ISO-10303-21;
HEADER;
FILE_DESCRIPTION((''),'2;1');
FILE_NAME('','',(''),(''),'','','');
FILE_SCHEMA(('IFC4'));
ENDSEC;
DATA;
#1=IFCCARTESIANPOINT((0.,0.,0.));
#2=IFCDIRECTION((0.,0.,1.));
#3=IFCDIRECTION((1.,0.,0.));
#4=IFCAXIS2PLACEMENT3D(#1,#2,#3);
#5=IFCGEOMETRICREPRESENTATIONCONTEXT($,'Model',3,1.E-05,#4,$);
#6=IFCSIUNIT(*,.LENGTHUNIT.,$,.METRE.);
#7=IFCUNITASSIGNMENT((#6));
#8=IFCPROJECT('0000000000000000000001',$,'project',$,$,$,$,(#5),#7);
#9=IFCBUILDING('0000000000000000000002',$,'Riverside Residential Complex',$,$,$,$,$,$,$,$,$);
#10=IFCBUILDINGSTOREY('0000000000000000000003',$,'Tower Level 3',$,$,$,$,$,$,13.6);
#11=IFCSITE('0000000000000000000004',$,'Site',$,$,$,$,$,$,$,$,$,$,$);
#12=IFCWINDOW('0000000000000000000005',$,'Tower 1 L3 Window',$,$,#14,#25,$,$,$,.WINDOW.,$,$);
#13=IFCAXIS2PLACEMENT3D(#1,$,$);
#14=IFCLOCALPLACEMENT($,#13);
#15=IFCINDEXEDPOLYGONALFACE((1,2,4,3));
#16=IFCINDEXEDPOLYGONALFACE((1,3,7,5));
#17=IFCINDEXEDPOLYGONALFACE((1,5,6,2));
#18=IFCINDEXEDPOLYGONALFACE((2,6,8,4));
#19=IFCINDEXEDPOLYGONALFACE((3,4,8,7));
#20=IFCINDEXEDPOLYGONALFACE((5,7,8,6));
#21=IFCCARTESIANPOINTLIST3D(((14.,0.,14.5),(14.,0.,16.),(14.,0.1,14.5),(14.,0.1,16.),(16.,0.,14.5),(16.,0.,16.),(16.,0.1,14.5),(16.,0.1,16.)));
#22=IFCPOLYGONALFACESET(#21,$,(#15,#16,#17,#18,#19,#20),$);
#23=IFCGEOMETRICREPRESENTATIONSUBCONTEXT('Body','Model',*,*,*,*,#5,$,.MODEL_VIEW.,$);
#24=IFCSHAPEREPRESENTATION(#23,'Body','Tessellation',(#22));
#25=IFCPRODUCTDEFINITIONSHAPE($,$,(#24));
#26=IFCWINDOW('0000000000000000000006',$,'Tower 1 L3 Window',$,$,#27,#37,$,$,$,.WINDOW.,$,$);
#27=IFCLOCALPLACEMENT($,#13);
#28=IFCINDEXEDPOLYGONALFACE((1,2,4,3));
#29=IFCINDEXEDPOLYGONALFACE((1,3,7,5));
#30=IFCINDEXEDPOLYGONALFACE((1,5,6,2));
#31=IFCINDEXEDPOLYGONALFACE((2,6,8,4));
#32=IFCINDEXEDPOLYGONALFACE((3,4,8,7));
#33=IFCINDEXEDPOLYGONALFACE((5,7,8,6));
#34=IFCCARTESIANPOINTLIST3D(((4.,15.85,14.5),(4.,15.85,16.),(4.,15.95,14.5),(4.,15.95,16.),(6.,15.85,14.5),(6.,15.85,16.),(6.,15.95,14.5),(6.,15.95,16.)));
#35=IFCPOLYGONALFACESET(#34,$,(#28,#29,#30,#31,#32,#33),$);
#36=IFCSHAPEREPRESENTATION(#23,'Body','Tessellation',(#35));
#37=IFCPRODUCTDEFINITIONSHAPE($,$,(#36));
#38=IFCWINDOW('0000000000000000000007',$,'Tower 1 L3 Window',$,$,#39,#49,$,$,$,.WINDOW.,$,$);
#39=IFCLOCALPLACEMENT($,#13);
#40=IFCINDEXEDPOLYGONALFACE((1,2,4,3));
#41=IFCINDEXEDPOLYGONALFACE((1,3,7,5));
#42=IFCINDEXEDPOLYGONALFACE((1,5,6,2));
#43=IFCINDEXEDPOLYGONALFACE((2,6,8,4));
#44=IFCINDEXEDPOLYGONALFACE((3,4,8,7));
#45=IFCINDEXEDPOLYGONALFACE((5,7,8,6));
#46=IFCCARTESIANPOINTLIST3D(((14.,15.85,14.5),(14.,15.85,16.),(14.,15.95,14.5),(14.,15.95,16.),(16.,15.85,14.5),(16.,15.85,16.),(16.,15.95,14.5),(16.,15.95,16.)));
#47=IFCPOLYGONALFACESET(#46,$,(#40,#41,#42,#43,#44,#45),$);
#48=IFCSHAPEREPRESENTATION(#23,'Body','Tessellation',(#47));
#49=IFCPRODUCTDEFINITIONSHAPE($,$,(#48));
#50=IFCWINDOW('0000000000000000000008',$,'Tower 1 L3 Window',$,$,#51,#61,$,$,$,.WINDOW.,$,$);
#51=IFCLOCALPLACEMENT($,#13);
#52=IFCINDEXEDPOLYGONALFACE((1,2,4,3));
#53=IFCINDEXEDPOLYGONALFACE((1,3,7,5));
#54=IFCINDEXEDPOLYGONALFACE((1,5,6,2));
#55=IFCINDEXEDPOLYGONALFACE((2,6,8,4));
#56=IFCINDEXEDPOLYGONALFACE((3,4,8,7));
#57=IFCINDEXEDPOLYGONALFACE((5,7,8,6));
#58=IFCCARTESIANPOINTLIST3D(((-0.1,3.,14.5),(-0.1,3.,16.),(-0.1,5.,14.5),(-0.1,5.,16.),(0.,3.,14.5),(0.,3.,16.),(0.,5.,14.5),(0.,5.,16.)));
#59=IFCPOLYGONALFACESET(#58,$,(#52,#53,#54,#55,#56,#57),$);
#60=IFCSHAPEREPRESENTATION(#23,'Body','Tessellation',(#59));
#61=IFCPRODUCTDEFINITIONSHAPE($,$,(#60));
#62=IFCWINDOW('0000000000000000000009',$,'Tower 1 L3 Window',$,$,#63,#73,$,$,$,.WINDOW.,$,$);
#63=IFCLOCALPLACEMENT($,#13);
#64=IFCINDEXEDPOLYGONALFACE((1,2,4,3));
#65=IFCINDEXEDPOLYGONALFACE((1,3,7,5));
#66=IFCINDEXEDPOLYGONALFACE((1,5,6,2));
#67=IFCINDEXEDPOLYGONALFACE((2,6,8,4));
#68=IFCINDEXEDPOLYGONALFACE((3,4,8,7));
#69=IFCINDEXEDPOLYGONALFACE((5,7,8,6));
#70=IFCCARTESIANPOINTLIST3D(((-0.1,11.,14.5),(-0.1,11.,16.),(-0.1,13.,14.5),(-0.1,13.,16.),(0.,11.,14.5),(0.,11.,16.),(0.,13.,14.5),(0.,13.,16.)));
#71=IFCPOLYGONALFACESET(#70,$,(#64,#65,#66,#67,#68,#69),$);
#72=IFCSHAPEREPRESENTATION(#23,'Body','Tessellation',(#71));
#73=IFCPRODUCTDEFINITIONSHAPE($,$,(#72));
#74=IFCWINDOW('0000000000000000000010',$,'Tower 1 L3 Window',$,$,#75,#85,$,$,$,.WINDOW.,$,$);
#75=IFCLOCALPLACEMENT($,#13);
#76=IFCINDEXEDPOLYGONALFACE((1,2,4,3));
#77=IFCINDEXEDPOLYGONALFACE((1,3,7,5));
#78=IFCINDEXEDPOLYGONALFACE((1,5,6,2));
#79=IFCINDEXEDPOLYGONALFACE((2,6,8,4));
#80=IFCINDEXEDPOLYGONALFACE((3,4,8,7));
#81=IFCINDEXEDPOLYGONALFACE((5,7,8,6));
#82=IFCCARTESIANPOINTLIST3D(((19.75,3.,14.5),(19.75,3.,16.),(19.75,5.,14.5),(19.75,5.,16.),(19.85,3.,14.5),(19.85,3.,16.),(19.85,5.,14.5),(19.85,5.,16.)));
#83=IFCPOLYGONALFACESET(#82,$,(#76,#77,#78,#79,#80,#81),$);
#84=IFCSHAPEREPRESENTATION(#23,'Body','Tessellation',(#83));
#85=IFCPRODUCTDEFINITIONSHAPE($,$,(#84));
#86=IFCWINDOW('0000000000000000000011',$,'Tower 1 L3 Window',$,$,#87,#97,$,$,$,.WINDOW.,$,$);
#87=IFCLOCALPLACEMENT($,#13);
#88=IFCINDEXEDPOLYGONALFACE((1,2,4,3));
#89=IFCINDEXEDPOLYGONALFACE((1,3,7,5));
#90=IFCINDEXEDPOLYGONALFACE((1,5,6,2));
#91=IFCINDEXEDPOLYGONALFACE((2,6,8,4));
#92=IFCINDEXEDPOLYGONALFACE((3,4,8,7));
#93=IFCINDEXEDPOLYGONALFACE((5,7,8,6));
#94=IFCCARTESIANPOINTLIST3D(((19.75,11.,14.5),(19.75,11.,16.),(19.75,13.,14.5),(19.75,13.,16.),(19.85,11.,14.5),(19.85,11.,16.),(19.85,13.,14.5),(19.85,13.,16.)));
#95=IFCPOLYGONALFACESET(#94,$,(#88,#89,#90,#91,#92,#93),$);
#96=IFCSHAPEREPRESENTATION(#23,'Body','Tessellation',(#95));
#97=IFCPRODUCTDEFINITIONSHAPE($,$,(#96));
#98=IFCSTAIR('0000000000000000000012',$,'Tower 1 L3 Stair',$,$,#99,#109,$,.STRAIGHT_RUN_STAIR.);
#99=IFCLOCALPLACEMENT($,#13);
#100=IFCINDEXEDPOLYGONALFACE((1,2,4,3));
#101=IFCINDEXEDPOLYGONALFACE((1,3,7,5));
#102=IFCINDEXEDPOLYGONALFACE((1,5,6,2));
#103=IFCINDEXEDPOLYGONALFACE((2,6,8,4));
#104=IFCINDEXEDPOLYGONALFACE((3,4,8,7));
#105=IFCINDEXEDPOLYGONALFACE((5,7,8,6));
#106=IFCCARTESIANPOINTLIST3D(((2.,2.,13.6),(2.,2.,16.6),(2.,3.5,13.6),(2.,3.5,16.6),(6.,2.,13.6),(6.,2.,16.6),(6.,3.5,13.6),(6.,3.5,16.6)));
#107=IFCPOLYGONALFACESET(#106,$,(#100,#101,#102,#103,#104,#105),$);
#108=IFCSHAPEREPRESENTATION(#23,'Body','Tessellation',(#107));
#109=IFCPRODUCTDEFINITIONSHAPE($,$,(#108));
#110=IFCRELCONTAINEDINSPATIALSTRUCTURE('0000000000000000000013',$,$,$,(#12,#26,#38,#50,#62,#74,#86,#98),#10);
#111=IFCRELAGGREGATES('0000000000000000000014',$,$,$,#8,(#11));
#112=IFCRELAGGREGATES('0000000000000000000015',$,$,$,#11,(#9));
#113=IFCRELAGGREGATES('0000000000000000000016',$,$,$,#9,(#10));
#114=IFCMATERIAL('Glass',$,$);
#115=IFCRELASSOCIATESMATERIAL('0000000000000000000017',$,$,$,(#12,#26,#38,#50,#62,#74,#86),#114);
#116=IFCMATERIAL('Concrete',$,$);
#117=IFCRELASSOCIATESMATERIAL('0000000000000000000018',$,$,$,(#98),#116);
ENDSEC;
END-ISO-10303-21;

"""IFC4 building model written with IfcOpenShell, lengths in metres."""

from ifc_helpers import new_model, si_unit, frame, origin_with_axes, place, context, subcontext, project, spatial, line, indexed_curve, outline, extrude, material, element, save


model = new_model("IFC4")

# Units and contexts
model_context = context("Model", 3, precision=1e-05, world=origin_with_axes())
body_context = subcontext(model_context, "Body", "Model", "MODEL_VIEW")
ifc_project = project(units=[si_unit("LENGTHUNIT", "METRE")], contexts=[model_context])

# Site, building, storey
site = spatial("IfcSite", under=ifc_project, Name="Site")
building = spatial("IfcBuilding", under=site, Name="Riverside Residential Complex")
storey = spatial("IfcBuildingStorey", under=building, Name="Tower Level 3", Elevation=13.6)

# Shared definitions
ifc_material_1 = material(Name="Concrete")

# Windows
ifc_material_2 = material(Name="Glass")
for number, where, z_axis, x_axis, name in (
    (1, (14.0, 0.0, 14.5), (0.0, 0.0, 1.0), (1.0, 0.0, 0.0), "Tower 1 L3 Window"),
    (2, (4.0, 15.85, 14.5), (0.0, 0.0, 1.0), (1.0, 0.0, 0.0), "Tower 1 L3 Window"),
    (3, (14.0, 15.85, 14.5), (0.0, 0.0, 1.0), (1.0, 0.0, 0.0), "Tower 1 L3 Window"),
    (4, (0.0, 3.0, 14.5), (0.0, 0.0, 1.0), (0.0, 1.0, 0.0), "Tower 1 L3 Window"),
    (5, (0.0, 11.0, 14.5), (0.0, 0.0, 1.0), (0.0, 1.0, 0.0), "Tower 1 L3 Window"),
    (6, (19.85, 3.0, 14.5), (0.0, 0.0, 1.0), (0.0, 1.0, 0.0), "Tower 1 L3 Window"),
    (7, (19.85, 11.0, 14.5), (0.0, 0.0, 1.0), (0.0, 1.0, 0.0), "Tower 1 L3 Window"),
):
    element("IfcWindow", number, at=place(None, frame(where, z_axis=z_axis, x_axis=x_axis)), inside=storey, material=ifc_material_2, Name=name, PredefinedType="WINDOW", context=body_context, shape_type="SweptSolid", body=[
        extrude(outline(indexed_curve([(0.0, 0.0), (2.0, 0.0), (2.0, 0.1), (0.0, 0.1)], segments=[line(1, 2, 3, 4, 1)])), origin_with_axes(), (0.0, 0.0, 1.0), 1.5),
    ])

# Stair
stair_placement = place(None, frame((2.0, 2.0, 13.6), z_axis=(0.0, 0.0, 1.0), x_axis=(1.0, 0.0, 0.0)))
element("IfcStair", 8, at=stair_placement, inside=storey, material=ifc_material_1, Name="Tower 1 L3 Stair", PredefinedType="STRAIGHT_RUN_STAIR", context=body_context, shape_type="SweptSolid", body=[
    extrude(outline(indexed_curve([(0.0, 0.0), (4.0, 0.0), (4.0, 1.5), (0.0, 1.5)], segments=[line(1, 2, 3, 4, 1)])), origin_with_axes(), (0.0, 0.0, 1.0), 3.0),
])

save(model, "model.ifc")
